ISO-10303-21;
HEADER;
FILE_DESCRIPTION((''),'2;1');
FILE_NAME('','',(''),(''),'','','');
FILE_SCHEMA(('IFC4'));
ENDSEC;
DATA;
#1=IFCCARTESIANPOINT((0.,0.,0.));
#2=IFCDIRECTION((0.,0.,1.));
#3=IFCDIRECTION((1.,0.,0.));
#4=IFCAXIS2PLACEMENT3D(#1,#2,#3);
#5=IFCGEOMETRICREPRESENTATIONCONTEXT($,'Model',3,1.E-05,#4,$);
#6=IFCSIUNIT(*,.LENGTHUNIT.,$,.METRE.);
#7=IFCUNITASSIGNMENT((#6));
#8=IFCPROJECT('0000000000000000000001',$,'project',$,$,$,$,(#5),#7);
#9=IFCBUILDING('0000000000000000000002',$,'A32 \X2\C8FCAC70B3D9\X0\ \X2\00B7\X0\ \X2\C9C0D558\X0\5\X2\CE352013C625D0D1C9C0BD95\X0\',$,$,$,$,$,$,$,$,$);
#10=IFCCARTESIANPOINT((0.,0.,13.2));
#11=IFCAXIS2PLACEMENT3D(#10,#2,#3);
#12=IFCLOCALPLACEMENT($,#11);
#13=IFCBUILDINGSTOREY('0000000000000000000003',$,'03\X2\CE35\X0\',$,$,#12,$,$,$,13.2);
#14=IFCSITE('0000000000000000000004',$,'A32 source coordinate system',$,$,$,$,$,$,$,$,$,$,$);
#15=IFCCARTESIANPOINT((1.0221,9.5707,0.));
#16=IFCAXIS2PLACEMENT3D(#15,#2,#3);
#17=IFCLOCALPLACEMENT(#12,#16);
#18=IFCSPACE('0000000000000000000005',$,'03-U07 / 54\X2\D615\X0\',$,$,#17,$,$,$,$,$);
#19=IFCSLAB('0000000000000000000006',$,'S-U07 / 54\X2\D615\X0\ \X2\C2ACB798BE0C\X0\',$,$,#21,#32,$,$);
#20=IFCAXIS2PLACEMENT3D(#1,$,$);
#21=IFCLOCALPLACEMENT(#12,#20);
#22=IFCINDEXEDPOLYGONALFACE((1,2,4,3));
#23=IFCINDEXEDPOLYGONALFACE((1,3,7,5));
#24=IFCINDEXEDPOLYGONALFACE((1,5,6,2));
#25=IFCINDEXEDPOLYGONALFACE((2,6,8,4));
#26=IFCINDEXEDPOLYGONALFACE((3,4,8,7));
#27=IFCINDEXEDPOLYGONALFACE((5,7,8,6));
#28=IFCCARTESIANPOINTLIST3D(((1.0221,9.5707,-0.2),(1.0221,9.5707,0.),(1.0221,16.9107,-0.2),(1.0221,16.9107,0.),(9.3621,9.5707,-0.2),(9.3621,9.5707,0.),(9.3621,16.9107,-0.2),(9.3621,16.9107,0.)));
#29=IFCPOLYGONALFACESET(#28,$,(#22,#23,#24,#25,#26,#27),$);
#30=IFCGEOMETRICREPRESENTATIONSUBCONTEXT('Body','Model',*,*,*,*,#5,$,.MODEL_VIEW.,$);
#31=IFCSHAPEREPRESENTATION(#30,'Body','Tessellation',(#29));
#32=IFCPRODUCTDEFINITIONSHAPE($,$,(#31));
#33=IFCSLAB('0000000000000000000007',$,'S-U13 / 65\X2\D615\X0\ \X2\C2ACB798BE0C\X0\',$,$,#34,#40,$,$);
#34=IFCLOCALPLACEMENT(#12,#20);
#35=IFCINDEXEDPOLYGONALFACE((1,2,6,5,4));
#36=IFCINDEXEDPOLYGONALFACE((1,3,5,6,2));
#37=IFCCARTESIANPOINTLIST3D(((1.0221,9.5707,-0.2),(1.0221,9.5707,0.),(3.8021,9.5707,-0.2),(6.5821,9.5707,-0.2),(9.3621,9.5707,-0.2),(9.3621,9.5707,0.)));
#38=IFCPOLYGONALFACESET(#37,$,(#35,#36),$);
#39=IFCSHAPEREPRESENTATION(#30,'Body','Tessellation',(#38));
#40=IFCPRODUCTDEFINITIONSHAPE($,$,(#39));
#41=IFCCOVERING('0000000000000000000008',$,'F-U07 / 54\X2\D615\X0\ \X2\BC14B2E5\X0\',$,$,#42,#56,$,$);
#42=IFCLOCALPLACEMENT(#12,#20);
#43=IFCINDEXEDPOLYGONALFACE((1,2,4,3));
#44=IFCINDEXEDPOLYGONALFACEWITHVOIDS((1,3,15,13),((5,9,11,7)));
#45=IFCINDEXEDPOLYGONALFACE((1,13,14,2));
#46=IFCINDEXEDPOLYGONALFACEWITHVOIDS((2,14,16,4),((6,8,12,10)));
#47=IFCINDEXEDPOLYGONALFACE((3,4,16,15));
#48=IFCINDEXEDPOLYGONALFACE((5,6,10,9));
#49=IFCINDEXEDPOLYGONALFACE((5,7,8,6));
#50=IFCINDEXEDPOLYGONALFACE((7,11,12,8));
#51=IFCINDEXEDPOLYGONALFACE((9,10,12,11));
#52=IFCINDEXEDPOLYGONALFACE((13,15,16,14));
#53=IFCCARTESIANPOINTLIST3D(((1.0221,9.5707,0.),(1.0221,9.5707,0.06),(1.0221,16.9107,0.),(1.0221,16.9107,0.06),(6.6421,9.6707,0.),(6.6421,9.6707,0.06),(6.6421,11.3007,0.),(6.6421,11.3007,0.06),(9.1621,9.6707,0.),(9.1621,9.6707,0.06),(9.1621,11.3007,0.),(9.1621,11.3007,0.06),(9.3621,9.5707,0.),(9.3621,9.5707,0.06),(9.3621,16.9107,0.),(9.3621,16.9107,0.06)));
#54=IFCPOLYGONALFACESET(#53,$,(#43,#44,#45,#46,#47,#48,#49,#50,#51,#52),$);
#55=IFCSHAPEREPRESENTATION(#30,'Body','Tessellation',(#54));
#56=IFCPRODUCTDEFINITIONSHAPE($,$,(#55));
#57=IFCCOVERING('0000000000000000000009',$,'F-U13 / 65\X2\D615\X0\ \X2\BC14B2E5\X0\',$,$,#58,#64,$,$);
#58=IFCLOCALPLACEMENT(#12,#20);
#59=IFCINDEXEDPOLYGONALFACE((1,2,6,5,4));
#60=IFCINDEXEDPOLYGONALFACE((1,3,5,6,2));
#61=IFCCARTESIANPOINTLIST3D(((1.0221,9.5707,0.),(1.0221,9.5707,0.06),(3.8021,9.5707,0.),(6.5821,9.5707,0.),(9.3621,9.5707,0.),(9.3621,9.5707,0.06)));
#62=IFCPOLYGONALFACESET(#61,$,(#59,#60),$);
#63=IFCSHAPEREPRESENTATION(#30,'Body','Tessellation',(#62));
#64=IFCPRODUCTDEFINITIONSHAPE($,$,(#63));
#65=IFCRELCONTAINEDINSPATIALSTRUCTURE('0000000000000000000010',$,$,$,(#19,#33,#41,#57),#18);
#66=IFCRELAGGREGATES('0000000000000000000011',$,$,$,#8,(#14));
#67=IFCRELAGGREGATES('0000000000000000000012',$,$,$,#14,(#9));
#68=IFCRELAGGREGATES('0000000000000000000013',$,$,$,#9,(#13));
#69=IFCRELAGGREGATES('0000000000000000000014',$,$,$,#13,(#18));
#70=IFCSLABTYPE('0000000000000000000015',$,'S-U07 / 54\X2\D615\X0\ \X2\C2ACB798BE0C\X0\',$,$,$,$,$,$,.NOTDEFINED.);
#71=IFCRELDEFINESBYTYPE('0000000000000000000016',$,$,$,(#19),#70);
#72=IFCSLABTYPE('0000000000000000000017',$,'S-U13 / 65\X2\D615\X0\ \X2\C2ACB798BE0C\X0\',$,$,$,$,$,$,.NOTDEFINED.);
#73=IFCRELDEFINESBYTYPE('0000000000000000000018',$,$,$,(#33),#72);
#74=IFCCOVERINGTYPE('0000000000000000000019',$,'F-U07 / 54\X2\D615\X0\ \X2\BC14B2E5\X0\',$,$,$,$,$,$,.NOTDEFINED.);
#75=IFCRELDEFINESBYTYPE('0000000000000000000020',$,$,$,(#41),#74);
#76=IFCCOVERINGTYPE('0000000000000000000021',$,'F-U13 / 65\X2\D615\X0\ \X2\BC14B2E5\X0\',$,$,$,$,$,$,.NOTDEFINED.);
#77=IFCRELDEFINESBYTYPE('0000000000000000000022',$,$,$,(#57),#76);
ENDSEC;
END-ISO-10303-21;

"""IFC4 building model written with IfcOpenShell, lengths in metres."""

from ifc_helpers import new_model, si_unit, frame, origin, origin_with_axes, place, context, subcontext, project, spatial, polyline, outline, extrude, source, transform, mapped, type_object, type_shapes, element, save


model = new_model("IFC4")

# Units and contexts
model_context = context("Model", 3, precision=1e-05, world=origin_with_axes())
body_context = subcontext(model_context, "Body", "Model", "MODEL_VIEW")
ifc_project = project(units=[si_unit("LENGTHUNIT", "METRE")], contexts=[model_context])

# Site, building, storey, space
storey_placement = place(None, frame((0.0, 0.0, 13.2), z_axis=(0.0, 0.0, 1.0), x_axis=(1.0, 0.0, 0.0)))
space_placement = place(storey_placement, frame((1.0221, 9.5707, 0.0), z_axis=(0.0, 0.0, 1.0), x_axis=(1.0, 0.0, 0.0)))
site = spatial("IfcSite", under=ifc_project, Name="A32 source coordinate system")
building = spatial("IfcBuilding", under=site, Name="A32 주거동 · 지하5층–옥탑지붕")
storey = spatial("IfcBuildingStorey", under=building, at=storey_placement, Name="03층", Elevation=13.2)
space = spatial("IfcSpace", under=storey, at=space_placement, Name="03-U07 / 54형")

# Slabs
slab_type_1 = type_object("IfcSlabType", Name="S-U07 / 54형 슬래브", PredefinedType="NOTDEFINED")
shared_shape_1 = source(origin(), body_context, "Body", "SweptSolid", [
    extrude(outline(polyline([(0.0, 0.0), (0.0, 7.34), (8.34, 7.34), (8.34, 0.0), (0.0, 0.0)])), frame((0.0, 0.0, -0.2)), (0.0, 0.0, 1.0), 0.2),
])
type_shapes(slab_type_1, [shared_shape_1])
slab_1_placement = place(space_placement, origin_with_axes())
element("IfcSlab", 1, at=slab_1_placement, inside=space, type_object=slab_type_1, Name="S-U07 / 54형 슬래브", context=body_context, shape_type="MappedRepresentation", body=[
    mapped(shared_shape_1, transform((0.0, 0.0, 0.0), scale=1.0)),
])
slab_type_2 = type_object("IfcSlabType", Name="S-U13 / 65형 슬래브", PredefinedType="NOTDEFINED")
shared_shape_2 = source(origin(), body_context, "Body", "SweptSolid", [
    extrude(outline(polyline([(0.0, 0.0), (8.34, 0.0), (8.34, 0.0), (0.0, 0.0), (0.0, 0.0)])), frame((0.0, 0.0, -0.2)), (0.0, 0.0, 1.0), 0.2),
])
type_shapes(slab_type_2, [shared_shape_2])
slab_2_placement = place(space_placement, origin_with_axes())
element("IfcSlab", 2, at=slab_2_placement, inside=space, type_object=slab_type_2, Name="S-U13 / 65형 슬래브", context=body_context, shape_type="MappedRepresentation", body=[
    mapped(shared_shape_2, transform((0.0, 0.0, 0.0), scale=1.0)),
])

# Coverings
covering_type_1 = type_object("IfcCoveringType", Name="F-U07 / 54형 바닥", PredefinedType="NOTDEFINED")
shared_shape_3 = source(origin(), body_context, "Body", "SweptSolid", [
    extrude(outline(polyline([(0.0, 0.0), (0.0, 7.34), (8.34, 7.34), (8.34, 0.0), (0.0, 0.0)]), holes=[polyline([(5.62, 1.73), (5.62, 0.1), (8.14, 0.1), (8.14, 1.73), (5.62, 1.73)])]), origin(), (0.0, 0.0, 1.0), 0.06),
])
type_shapes(covering_type_1, [shared_shape_3])
covering_1_placement = place(space_placement, origin_with_axes())
element("IfcCovering", 3, at=covering_1_placement, inside=space, type_object=covering_type_1, Name="F-U07 / 54형 바닥", context=body_context, shape_type="MappedRepresentation", body=[
    mapped(shared_shape_3, transform((0.0, 0.0, 0.0), scale=1.0)),
])
covering_type_2 = type_object("IfcCoveringType", Name="F-U13 / 65형 바닥", PredefinedType="NOTDEFINED")
shared_shape_4 = source(origin(), body_context, "Body", "SweptSolid", [
    extrude(outline(polyline([(0.0, 0.0), (8.34, 0.0), (8.34, 0.0), (0.0, 0.0), (0.0, 0.0)])), origin(), (0.0, 0.0, 1.0), 0.06),
])
type_shapes(covering_type_2, [shared_shape_4])
covering_2_placement = place(space_placement, origin_with_axes())
element("IfcCovering", 4, at=covering_2_placement, inside=space, type_object=covering_type_2, Name="F-U13 / 65형 바닥", context=body_context, shape_type="MappedRepresentation", body=[
    mapped(shared_shape_4, transform((0.0, 0.0, 0.0), scale=1.0)),
])

save(model, "model.ifc")
